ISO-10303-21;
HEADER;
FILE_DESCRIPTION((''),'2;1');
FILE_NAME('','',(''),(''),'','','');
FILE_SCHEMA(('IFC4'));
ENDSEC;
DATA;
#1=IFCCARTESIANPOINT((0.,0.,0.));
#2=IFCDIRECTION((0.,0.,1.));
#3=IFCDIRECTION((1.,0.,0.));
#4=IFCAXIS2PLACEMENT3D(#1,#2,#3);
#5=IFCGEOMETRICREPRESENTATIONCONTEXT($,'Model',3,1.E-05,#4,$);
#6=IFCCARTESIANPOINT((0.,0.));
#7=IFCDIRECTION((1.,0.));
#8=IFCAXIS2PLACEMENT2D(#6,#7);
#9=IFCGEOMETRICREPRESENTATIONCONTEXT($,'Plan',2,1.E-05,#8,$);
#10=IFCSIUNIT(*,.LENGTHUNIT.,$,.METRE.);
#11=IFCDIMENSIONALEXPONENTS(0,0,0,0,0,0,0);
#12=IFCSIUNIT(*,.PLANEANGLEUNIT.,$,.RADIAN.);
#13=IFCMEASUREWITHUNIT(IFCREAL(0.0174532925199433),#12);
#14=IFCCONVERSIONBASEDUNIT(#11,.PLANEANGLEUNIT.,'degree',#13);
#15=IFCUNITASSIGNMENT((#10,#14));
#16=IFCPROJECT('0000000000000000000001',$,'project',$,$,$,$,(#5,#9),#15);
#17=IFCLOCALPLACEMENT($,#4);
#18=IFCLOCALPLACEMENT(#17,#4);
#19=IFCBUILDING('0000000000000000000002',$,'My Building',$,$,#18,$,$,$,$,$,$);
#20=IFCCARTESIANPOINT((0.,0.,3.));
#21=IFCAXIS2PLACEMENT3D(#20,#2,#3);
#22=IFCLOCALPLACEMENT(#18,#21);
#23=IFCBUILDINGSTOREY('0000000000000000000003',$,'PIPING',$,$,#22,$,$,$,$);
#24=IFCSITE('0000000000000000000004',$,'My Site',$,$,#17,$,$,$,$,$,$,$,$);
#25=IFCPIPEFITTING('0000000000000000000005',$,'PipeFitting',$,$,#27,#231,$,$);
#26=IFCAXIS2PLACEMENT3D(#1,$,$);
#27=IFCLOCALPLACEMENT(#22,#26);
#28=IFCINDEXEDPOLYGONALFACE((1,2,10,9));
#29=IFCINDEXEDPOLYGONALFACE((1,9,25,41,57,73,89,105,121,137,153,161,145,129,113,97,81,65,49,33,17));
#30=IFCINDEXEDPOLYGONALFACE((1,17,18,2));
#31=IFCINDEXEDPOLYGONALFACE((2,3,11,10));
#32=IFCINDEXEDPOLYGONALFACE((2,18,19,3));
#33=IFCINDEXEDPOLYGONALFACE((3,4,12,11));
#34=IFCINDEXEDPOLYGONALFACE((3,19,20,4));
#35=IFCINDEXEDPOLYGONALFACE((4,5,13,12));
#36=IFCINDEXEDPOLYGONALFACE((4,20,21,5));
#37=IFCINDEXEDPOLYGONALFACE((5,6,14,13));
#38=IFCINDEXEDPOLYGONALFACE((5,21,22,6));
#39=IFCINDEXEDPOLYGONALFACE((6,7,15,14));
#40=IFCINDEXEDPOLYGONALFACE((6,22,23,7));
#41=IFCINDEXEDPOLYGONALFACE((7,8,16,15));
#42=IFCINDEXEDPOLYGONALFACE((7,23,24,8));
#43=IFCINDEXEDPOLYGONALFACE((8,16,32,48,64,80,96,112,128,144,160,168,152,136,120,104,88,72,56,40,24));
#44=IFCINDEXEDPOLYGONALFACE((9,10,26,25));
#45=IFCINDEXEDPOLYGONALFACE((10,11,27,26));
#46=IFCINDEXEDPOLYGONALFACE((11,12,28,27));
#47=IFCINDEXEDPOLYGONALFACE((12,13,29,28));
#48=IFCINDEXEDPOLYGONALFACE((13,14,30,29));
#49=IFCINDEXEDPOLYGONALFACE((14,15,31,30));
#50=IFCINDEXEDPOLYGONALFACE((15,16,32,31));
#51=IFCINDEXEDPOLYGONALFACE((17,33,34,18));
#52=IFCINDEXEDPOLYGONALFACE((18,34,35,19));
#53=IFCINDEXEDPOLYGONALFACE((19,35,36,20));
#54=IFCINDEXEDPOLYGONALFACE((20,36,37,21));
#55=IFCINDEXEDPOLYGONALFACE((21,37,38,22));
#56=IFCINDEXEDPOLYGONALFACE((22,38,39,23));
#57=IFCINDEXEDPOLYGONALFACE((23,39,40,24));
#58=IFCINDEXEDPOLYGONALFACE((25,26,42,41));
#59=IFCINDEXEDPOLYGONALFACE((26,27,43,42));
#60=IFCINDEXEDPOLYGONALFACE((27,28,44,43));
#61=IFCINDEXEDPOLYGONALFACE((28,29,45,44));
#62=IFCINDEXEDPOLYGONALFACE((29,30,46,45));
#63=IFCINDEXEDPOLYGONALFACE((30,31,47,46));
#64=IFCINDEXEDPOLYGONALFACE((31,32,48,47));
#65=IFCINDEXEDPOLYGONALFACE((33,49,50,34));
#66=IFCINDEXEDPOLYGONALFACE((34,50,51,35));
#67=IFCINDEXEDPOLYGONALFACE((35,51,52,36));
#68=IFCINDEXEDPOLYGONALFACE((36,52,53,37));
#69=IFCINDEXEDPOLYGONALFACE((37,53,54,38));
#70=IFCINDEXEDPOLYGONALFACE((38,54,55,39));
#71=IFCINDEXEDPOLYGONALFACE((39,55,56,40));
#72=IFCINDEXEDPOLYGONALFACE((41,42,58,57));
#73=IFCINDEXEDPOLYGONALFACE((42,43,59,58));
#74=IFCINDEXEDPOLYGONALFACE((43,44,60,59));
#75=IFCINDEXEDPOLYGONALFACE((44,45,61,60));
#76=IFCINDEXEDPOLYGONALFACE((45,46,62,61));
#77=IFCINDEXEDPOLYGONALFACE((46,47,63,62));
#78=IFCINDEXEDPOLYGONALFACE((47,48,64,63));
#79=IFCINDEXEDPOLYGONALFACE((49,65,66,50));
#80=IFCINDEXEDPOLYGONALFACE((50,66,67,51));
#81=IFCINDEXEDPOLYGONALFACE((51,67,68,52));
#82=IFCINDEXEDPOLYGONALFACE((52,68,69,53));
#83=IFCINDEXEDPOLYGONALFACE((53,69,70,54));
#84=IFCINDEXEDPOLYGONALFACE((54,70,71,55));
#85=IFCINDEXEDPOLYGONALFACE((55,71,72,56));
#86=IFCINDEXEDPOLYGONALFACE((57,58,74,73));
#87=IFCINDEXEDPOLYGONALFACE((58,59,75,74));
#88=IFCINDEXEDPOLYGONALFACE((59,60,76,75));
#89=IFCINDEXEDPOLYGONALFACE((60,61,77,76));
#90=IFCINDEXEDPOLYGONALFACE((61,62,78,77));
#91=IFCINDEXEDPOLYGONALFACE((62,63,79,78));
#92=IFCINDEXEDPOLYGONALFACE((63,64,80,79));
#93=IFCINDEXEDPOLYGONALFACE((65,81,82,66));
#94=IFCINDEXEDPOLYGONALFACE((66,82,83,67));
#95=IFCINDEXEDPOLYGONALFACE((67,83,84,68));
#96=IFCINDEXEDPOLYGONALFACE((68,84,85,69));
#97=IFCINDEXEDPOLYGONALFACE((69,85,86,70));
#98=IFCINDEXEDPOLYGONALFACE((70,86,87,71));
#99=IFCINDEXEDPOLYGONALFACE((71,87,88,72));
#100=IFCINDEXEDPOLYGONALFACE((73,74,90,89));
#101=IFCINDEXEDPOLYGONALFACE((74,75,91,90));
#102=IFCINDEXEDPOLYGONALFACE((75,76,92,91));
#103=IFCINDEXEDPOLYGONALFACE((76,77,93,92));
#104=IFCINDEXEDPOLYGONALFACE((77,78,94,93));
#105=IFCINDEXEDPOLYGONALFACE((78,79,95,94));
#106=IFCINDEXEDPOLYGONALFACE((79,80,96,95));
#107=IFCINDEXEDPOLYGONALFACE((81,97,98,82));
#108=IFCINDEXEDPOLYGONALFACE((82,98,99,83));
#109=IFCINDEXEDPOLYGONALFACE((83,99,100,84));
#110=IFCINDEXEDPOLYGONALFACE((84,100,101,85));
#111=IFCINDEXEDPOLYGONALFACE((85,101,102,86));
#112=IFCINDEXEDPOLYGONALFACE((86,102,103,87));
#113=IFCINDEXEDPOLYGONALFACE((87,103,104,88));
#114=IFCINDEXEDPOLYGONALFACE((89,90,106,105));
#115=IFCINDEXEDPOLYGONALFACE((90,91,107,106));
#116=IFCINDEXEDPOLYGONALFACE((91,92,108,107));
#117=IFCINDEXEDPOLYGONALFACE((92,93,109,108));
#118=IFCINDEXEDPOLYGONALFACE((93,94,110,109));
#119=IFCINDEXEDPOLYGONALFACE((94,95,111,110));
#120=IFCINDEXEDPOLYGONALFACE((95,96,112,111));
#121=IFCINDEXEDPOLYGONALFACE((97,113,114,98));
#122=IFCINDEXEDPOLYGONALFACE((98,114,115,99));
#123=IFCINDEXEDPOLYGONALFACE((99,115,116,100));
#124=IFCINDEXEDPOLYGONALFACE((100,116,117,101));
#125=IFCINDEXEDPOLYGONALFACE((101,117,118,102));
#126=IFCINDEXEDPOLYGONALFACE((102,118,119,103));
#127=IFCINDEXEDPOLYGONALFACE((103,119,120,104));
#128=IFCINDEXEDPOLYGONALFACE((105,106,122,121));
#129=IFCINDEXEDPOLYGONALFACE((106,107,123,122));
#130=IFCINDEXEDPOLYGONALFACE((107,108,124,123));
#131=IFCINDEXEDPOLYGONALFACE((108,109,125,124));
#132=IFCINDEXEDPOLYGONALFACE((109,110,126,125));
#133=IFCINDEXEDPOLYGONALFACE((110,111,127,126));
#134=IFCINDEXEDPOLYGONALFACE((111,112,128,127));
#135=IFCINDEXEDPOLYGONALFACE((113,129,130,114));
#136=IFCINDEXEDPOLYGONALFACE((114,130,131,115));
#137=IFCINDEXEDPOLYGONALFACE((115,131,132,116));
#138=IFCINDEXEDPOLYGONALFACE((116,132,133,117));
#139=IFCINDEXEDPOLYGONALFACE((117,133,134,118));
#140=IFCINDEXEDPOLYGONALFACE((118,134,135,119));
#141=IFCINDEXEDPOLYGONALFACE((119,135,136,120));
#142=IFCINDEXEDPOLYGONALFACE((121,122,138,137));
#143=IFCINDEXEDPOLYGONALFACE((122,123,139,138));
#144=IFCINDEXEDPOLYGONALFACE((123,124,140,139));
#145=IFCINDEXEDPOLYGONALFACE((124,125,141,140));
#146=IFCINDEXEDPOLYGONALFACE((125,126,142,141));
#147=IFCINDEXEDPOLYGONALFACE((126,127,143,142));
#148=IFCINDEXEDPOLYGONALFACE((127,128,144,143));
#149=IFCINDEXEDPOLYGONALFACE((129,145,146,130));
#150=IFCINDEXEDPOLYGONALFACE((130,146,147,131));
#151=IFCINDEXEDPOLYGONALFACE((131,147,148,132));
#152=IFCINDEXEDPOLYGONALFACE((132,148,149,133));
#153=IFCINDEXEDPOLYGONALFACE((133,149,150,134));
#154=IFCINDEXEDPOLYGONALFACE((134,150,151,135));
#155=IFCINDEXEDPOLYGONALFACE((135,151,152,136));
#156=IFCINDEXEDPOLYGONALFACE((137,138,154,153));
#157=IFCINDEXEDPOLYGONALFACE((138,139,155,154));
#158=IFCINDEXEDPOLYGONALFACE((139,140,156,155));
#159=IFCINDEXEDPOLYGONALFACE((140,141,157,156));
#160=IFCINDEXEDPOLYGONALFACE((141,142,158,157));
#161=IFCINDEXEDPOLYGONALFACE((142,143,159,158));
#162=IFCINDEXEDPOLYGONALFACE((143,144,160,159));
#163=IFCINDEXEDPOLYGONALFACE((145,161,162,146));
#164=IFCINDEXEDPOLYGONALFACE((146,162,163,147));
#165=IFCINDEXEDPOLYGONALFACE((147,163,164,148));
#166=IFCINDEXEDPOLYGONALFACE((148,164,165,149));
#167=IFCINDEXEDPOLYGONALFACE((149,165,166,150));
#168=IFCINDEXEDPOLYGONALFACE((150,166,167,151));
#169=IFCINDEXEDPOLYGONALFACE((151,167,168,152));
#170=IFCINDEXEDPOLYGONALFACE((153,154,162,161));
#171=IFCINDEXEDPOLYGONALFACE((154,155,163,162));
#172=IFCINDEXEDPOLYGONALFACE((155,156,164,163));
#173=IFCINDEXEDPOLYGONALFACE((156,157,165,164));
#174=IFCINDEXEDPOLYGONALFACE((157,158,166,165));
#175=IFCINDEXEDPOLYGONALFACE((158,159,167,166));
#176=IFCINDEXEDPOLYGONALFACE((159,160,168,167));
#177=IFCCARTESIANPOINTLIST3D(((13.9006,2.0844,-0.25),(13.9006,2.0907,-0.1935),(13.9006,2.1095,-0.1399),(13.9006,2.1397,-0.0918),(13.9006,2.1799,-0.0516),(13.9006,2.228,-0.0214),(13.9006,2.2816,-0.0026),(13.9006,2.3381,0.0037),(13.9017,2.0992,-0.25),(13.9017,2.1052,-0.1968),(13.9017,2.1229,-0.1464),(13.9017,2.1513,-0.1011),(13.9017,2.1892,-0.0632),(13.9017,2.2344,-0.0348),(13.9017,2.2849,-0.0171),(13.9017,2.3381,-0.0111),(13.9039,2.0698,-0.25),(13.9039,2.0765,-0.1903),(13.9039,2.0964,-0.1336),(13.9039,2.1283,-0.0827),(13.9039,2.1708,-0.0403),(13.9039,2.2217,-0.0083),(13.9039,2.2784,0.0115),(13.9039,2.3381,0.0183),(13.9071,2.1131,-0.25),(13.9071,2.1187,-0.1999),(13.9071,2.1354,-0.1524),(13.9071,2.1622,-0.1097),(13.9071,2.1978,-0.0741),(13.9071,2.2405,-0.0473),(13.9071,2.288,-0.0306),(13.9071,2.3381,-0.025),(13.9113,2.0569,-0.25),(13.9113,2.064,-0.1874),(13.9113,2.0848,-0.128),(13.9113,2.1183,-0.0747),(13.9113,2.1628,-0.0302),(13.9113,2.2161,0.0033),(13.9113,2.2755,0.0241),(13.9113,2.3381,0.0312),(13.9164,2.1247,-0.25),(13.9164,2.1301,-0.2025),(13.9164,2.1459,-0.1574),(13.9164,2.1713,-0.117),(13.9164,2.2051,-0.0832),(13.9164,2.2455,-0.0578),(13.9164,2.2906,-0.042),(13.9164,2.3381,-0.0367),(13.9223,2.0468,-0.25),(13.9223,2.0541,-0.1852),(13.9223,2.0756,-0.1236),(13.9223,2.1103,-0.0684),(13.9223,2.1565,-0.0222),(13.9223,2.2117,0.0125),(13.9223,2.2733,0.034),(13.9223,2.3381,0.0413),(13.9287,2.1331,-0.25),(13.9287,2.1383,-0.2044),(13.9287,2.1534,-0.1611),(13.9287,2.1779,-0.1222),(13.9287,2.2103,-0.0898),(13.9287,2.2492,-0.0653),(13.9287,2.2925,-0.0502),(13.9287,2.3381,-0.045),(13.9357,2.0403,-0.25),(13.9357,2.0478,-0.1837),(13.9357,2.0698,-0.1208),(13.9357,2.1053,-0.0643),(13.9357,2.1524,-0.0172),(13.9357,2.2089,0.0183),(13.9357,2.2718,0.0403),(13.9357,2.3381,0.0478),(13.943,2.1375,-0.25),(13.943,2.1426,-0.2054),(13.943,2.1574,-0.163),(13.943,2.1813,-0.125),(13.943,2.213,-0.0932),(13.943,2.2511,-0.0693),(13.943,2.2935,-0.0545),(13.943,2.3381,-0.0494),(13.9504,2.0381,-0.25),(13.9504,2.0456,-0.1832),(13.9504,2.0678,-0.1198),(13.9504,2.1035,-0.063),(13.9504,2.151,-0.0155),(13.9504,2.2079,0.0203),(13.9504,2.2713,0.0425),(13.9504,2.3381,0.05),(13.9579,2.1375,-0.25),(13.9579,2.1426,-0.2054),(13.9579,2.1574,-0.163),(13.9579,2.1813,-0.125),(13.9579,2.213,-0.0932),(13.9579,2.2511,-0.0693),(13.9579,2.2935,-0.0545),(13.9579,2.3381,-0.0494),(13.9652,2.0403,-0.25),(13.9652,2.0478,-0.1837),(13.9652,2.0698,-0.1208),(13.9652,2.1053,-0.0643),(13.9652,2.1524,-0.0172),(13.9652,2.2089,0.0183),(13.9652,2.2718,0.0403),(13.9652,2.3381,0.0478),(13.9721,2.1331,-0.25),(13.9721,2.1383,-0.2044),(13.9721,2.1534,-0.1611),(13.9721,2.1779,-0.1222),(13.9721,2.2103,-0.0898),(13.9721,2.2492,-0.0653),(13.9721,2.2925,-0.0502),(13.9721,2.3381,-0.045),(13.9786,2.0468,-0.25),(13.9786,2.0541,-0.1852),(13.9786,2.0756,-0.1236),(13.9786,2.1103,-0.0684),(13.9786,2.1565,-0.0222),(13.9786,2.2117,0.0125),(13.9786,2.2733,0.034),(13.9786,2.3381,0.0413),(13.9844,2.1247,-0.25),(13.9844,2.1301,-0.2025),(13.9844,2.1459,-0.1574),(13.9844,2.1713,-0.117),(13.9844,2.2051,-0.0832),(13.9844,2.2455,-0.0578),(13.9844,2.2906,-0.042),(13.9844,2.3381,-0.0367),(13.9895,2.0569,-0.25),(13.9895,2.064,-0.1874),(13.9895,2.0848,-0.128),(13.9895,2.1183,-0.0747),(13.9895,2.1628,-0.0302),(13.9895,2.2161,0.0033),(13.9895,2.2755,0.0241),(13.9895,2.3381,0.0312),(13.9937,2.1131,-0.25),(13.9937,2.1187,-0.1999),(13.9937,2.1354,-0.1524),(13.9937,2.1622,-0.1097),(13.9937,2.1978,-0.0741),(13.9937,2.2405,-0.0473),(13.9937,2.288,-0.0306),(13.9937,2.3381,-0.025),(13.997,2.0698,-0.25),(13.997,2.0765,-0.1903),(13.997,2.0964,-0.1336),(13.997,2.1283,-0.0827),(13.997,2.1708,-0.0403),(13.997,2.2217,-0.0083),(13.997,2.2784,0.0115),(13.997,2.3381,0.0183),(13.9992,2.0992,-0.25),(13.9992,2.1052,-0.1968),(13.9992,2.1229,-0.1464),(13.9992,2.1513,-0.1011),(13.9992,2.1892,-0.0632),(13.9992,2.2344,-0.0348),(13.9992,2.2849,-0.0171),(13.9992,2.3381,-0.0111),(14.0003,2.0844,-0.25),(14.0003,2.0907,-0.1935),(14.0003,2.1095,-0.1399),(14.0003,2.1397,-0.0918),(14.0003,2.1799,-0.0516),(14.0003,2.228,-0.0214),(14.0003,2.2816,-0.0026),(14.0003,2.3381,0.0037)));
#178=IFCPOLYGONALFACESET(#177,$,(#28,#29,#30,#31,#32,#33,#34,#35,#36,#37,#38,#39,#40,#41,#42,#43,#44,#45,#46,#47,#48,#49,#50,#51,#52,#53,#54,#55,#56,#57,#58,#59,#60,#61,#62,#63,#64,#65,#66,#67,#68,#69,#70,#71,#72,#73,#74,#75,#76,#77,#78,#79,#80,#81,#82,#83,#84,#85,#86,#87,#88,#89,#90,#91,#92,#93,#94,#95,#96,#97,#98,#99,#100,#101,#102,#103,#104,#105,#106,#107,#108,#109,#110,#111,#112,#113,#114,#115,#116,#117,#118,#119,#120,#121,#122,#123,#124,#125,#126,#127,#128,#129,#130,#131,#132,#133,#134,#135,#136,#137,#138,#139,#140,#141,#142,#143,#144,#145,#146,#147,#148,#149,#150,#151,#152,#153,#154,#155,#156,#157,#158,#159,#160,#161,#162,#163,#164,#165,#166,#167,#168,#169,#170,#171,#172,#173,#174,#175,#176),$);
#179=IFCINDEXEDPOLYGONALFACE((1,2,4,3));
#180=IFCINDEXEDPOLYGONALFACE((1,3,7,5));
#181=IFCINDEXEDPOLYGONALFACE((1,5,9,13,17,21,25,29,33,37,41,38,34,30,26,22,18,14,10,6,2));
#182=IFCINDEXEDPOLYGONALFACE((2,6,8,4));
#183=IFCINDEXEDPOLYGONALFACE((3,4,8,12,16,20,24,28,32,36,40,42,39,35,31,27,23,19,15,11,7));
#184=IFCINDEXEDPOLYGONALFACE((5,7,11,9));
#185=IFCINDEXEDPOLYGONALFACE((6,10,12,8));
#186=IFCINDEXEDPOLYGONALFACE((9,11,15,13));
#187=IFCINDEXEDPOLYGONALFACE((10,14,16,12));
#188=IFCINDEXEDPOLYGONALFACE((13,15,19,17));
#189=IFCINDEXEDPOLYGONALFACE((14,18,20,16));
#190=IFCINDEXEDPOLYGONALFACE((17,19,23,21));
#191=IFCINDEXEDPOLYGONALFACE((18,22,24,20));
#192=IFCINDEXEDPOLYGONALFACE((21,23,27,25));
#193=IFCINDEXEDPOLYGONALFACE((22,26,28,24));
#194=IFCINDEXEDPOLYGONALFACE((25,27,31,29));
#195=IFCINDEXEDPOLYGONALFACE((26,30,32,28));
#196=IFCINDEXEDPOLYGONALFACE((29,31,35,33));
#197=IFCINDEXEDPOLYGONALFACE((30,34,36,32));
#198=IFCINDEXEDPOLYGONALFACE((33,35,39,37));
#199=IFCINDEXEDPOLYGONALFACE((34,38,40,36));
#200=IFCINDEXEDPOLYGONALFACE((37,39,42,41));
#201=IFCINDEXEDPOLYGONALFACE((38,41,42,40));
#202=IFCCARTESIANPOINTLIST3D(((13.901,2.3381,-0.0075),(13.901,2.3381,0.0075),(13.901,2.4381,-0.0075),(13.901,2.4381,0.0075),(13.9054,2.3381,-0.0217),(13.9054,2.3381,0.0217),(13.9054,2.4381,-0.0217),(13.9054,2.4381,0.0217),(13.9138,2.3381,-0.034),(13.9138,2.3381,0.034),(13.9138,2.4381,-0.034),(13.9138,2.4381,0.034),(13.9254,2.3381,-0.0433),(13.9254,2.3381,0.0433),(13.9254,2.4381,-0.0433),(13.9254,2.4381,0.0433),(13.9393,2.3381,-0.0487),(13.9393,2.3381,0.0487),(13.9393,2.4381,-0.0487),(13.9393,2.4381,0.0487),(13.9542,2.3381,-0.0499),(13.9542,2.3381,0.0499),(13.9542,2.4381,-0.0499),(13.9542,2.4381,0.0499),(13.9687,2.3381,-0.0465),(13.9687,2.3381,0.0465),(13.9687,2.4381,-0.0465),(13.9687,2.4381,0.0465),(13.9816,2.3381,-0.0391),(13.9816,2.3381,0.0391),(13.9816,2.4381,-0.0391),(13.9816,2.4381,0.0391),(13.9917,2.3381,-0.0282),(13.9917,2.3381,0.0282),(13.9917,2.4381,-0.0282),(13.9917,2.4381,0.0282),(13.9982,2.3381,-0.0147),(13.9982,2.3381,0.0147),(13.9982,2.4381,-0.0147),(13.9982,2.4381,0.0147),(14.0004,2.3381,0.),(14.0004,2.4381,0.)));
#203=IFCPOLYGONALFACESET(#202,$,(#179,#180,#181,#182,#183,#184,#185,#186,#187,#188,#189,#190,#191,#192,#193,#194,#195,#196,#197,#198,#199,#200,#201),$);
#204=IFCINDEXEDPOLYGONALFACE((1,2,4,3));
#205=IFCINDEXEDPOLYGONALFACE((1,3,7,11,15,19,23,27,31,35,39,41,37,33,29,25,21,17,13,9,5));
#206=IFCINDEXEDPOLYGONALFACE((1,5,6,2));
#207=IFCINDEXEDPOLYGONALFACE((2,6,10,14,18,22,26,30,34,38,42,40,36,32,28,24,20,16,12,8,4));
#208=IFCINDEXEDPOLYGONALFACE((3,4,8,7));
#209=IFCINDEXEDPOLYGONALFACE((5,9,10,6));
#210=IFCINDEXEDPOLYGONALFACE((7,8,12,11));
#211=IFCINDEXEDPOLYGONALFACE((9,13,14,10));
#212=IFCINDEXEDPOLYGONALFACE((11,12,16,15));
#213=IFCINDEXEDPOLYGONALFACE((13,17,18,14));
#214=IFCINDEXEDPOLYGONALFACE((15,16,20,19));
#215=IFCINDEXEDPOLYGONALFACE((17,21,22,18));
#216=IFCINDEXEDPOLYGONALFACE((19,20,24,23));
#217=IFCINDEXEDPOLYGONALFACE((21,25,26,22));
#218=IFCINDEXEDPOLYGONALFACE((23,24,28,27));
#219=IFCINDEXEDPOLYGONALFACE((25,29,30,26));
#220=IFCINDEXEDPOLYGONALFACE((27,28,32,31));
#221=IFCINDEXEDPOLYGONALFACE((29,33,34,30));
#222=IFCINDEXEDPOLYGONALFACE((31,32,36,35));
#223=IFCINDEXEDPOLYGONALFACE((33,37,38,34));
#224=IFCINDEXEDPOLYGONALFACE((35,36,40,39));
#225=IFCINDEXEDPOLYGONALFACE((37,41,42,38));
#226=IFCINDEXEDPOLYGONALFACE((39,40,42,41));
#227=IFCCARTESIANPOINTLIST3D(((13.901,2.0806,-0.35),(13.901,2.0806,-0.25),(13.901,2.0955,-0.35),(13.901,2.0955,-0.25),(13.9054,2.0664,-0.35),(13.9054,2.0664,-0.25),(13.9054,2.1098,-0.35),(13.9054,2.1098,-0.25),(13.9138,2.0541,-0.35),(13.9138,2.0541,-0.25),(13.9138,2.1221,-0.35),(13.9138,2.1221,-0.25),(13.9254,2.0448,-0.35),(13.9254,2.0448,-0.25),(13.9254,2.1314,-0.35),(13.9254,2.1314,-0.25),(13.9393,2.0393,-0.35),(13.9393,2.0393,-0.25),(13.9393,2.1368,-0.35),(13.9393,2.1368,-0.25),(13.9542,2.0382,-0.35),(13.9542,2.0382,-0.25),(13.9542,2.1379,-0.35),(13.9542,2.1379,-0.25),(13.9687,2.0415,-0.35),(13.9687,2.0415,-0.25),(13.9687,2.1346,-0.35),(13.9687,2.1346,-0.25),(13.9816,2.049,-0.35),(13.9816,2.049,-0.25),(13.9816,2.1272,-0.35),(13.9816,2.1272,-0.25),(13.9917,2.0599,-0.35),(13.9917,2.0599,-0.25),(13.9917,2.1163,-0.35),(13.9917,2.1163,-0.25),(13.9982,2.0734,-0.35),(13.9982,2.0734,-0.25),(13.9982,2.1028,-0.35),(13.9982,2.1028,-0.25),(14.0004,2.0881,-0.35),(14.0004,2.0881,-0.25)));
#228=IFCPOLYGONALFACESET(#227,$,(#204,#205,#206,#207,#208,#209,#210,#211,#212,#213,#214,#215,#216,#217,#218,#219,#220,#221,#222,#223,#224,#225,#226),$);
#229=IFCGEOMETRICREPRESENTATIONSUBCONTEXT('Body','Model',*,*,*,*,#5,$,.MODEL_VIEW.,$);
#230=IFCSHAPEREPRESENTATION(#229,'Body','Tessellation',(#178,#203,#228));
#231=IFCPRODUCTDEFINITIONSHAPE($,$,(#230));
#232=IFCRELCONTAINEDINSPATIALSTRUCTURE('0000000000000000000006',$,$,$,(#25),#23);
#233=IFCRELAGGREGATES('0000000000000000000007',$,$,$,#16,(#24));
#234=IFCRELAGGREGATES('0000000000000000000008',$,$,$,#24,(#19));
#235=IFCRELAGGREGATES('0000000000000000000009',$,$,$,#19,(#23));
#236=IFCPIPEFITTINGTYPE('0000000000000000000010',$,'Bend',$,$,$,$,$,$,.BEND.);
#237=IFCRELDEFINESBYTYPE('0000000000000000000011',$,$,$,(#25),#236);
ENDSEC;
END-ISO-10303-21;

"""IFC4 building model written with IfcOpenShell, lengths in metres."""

from ifc_helpers import new_model, entity, si_unit, converted_unit, frame, origin_with_axes, origin_2d_with_axis, place, context, subcontext, project, spatial, circle, extrude, source, transform, mapped, type_object, type_shapes, element, save


model = new_model("IFC4")

# Units and contexts
model_context = context("Model", 3, precision=1e-05, world=origin_with_axes())
plan_context = context("Plan", 2, precision=1e-05, world=origin_2d_with_axis())
body_context = subcontext(model_context, "Body", "Model", "MODEL_VIEW")
ifc_project = project(units=[si_unit("LENGTHUNIT", "METRE"), converted_unit("PLANEANGLEUNIT", "degree", entity("IfcReal", 0.0174532925199433), si_unit("PLANEANGLEUNIT", "RADIAN"), dimensions=[0, 0, 0, 0, 0, 0, 0])], contexts=[model_context, plan_context])

# Site, building, storey
site_placement = place(None, origin_with_axes())
site = spatial("IfcSite", under=ifc_project, at=site_placement, Name="My Site")
building_placement = place(site_placement, origin_with_axes())
building = spatial("IfcBuilding", under=site, at=building_placement, Name="My Building")
storey_placement = place(building_placement, frame((0.0, 0.0, 3.0), z_axis=(0.0, 0.0, 1.0), x_axis=(1.0, 0.0, 0.0)))
storey = spatial("IfcBuildingStorey", under=building, at=storey_placement, Name="PIPING")

# Pipe fitting
pipe_fitting_type = type_object("IfcPipeFittingType", Name="Bend", PredefinedType="BEND")
shared_shape = source(origin_with_axes(), body_context, "Body", "SolidModel", [
    entity("IfcSweptDiskSolid", entity("IfcIndexedPolyCurve", entity("IfcCartesianPointList3D", [[0.0, 0.0, 0.1], [0.0, -0.0732, 0.2768], [0.0, -0.25, 0.35]]), [entity("IfcArcIndex", [1, 2, 3])]), 0.05),
    extrude(circle(Radius=0.05), origin_with_axes(), (0.0, 0.0, 1.0), 0.1),
    extrude(circle(Radius=0.05), frame((0.0, -0.25, 0.35), z_axis=(0.0, -1.0, 0.0), x_axis=(1.0, 0.0, 0.0)), (0.0, 0.0, 1.0), 0.1),
])
type_shapes(pipe_fitting_type, [shared_shape])
for number, where, z_axis, x_axis, name in (
    (1, (13.9504, 2.4381, 0.0), (0.0, -1.0, 0.0), (1.0, 0.0, 0.0), "PipeFitting"),
):
    element("IfcPipeFitting", number, at=place(storey_placement, frame(where, z_axis=z_axis, x_axis=x_axis)), inside=storey, type_object=pipe_fitting_type, Name=name, context=body_context, shape_type="MappedRepresentation", body=[
        mapped(shared_shape, transform((0.0, 0.0, 0.0), x_axis=(1.0, 0.0, 0.0), y_axis=(0.0, 1.0, 0.0), z_axis=(0.0, 0.0, 1.0), scale=1.0)),
    ])

save(model, "model.ifc")
